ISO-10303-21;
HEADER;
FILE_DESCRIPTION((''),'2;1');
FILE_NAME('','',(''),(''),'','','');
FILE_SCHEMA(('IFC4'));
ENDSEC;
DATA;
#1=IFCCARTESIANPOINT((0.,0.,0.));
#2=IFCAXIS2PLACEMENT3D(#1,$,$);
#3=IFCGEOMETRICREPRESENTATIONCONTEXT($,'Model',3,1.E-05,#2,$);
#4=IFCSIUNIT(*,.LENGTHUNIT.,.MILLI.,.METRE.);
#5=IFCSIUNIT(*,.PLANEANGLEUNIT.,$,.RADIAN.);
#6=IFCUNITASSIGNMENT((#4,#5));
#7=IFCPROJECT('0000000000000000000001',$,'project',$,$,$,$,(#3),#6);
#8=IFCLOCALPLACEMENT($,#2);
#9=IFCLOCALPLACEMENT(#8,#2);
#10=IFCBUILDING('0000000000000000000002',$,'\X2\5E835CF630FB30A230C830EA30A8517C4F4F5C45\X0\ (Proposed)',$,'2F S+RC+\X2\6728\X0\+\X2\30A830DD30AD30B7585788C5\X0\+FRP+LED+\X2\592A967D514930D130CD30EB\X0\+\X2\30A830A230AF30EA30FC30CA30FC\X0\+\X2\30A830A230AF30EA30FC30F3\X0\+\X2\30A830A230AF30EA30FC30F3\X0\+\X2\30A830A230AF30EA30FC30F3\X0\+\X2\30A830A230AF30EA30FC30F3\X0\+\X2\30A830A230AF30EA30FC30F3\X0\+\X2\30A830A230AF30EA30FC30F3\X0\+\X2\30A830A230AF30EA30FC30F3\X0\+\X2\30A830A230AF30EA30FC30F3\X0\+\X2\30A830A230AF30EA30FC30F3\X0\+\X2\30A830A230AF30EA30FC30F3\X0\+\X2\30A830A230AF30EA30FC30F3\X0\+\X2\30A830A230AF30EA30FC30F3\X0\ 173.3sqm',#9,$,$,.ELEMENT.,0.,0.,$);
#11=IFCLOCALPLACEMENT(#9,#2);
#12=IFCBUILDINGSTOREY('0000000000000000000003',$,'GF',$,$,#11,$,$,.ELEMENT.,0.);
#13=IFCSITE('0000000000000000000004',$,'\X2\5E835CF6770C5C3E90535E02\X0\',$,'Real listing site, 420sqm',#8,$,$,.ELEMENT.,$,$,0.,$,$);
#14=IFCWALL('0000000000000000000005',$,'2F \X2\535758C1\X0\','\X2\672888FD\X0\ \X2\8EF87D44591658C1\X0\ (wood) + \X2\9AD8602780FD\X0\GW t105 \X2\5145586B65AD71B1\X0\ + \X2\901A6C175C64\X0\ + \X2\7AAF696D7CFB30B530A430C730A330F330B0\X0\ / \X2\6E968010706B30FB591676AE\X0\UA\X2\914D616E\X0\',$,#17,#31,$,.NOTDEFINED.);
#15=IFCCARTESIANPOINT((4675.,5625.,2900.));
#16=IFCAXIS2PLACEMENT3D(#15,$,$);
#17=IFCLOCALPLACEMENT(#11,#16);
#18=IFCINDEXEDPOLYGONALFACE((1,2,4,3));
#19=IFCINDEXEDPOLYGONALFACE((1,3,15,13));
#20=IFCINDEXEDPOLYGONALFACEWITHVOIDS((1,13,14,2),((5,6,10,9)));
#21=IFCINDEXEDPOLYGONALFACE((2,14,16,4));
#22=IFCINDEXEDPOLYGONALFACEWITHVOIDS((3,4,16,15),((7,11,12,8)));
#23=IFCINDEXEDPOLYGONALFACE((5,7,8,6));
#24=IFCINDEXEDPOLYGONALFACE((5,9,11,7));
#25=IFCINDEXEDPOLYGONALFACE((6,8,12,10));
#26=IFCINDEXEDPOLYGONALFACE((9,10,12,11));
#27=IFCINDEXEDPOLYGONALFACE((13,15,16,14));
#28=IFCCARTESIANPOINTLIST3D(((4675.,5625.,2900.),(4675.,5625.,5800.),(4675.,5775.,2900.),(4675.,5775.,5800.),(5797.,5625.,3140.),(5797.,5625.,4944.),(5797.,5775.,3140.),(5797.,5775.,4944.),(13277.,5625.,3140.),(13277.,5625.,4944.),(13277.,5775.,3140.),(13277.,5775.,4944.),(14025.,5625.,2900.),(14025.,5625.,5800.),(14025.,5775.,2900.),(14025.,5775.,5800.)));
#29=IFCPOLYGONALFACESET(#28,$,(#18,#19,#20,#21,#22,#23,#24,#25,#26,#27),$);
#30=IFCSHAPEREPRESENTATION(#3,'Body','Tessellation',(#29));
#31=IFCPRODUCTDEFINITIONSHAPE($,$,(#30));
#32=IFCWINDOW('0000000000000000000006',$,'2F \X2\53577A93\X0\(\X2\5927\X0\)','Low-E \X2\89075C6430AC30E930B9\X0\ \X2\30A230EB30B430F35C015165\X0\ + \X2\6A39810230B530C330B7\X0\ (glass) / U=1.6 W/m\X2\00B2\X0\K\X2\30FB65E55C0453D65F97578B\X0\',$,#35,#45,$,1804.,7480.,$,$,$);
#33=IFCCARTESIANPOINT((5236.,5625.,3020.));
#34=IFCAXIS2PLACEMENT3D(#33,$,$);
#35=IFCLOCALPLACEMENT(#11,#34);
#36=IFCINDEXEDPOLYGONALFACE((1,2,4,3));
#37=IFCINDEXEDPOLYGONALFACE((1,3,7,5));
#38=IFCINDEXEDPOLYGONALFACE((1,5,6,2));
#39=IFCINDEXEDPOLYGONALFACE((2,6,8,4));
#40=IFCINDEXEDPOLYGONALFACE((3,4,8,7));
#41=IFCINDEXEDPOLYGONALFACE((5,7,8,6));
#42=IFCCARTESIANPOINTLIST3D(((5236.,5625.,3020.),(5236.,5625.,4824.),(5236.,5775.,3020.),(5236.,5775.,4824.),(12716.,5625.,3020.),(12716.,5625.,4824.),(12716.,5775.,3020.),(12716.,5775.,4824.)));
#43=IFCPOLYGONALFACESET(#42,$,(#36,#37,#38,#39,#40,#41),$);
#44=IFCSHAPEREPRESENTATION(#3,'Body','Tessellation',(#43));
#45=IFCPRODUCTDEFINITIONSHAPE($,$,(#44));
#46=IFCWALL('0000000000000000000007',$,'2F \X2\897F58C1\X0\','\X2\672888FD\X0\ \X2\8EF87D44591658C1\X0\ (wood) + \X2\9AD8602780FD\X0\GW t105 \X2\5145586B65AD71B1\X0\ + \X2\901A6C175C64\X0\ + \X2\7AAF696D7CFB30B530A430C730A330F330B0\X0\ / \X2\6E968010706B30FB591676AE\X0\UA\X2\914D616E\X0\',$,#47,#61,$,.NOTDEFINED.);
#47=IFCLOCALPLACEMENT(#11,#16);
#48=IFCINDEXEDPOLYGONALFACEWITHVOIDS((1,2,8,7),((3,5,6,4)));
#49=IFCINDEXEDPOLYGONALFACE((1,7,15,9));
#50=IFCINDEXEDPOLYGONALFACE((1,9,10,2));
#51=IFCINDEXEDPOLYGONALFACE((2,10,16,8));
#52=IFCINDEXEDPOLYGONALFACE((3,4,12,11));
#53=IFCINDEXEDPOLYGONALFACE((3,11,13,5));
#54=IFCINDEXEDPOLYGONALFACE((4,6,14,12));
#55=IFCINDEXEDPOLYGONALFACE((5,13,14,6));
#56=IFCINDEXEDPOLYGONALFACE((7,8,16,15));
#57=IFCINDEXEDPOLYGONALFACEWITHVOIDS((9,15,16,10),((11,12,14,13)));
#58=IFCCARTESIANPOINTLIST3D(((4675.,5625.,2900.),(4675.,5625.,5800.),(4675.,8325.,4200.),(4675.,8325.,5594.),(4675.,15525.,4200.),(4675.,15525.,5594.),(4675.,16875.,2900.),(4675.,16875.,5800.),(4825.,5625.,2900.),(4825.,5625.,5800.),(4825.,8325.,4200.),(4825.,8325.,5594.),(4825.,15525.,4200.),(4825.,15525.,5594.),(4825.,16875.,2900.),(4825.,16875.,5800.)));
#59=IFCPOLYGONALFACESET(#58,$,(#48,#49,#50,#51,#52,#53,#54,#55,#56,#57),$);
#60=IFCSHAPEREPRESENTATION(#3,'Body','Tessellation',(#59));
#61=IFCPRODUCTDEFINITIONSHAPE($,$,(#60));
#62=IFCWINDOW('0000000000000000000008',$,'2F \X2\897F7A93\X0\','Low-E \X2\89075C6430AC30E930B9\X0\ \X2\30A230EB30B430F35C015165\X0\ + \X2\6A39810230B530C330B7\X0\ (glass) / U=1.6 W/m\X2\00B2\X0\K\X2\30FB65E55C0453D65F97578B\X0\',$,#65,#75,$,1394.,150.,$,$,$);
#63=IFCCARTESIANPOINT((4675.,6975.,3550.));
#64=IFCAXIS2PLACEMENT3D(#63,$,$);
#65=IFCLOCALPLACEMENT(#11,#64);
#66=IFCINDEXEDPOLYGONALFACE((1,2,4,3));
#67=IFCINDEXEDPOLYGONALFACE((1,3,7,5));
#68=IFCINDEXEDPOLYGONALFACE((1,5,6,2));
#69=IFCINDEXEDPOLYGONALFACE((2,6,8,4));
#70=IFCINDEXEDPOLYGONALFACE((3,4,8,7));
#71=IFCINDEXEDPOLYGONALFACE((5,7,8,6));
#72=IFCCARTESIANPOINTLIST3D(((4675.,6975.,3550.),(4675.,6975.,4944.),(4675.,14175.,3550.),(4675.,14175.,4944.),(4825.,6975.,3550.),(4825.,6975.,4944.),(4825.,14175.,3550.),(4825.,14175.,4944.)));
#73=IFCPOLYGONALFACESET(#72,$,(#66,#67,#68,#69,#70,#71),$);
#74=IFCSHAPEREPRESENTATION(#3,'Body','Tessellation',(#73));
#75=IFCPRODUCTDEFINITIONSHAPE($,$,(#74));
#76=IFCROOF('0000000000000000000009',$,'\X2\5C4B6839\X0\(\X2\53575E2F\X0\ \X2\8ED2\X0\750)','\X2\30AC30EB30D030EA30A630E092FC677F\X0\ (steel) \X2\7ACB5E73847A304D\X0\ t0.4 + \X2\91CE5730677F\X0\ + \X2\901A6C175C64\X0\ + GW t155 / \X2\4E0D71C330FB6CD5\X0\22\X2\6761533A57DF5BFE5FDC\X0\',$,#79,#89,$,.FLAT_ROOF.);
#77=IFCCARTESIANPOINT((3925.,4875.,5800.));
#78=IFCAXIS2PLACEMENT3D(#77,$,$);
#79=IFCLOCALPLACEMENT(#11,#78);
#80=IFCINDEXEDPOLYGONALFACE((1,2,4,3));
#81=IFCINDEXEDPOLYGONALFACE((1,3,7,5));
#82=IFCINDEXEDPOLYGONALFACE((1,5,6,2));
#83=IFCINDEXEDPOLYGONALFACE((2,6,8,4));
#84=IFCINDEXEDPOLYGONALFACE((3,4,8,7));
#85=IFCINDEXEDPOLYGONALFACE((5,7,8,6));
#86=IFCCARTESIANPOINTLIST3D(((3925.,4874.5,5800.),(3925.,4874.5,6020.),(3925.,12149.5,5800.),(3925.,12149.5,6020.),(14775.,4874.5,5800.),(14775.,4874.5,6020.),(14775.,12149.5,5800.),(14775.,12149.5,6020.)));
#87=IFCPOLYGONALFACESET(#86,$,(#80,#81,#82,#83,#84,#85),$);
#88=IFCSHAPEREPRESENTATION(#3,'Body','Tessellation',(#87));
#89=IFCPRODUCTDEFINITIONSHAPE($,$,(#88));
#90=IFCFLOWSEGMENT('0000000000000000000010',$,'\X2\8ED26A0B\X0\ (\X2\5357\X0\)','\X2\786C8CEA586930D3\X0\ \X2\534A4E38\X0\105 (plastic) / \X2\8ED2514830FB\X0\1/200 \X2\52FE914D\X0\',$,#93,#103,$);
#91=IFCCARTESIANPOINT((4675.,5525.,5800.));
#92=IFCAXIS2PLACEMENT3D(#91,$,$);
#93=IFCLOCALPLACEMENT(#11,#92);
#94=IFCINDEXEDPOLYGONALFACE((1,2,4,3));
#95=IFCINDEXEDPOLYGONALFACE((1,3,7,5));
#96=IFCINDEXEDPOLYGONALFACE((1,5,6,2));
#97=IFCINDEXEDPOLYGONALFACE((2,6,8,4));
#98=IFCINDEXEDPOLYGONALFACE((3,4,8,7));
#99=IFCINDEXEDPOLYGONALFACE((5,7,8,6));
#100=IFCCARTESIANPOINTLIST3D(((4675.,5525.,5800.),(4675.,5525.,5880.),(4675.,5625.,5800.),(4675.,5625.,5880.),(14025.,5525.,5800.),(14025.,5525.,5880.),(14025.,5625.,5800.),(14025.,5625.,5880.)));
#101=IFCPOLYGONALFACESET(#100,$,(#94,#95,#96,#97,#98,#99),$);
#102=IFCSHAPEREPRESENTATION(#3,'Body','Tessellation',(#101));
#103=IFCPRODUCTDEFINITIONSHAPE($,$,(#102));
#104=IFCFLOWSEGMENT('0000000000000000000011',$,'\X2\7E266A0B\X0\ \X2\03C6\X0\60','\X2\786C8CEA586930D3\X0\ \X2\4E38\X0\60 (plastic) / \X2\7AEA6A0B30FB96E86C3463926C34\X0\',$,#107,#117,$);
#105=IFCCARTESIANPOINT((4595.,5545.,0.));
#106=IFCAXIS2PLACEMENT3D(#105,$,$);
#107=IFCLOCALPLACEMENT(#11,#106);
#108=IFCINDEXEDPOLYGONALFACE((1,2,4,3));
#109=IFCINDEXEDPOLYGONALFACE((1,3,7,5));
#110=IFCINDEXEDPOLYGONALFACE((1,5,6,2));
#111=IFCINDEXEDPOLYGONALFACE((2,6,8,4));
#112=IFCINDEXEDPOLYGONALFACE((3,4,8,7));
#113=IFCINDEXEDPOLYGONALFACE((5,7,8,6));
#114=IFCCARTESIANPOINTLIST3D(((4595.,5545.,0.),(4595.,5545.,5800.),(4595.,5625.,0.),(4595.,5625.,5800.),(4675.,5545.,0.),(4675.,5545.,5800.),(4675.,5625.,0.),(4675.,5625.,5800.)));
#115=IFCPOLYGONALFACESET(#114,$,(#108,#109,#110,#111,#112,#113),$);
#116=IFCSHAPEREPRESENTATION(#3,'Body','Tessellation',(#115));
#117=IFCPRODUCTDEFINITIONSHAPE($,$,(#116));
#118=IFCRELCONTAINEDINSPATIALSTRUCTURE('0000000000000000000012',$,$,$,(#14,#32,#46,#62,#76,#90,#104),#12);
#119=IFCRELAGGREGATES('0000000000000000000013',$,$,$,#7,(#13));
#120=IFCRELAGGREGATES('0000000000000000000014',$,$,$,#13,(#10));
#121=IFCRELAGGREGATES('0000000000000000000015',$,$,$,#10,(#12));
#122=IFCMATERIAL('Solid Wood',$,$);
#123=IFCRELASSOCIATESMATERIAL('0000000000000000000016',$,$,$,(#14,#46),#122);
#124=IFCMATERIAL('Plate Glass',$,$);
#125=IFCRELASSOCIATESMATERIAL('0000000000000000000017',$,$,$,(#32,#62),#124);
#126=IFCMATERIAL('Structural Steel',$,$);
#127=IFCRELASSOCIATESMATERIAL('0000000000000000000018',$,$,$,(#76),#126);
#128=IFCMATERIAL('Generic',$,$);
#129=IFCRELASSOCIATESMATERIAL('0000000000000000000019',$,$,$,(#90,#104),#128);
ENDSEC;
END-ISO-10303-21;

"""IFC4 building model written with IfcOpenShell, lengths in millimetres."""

from ifc_helpers import new_model, si_unit, frame, frame_2d, origin, place, context, project, spatial, rectangle, extrude, material, element, fill, save


model = new_model("IFC4")

# Units and contexts
model_context = context("Model", 3, precision=1e-05, world=origin())
ifc_project = project(units=[si_unit("LENGTHUNIT", "METRE", prefix="MILLI"), si_unit("PLANEANGLEUNIT", "RADIAN")], contexts=[model_context])

# Site, building, storey
site_placement = place(None, origin())
site = spatial("IfcSite", under=ifc_project, at=site_placement, Name="広島県尾道市", ObjectType="Real listing site, 420sqm", CompositionType="ELEMENT", RefElevation=0.0)
building_placement = place(site_placement, origin())
building = spatial("IfcBuilding", under=site, at=building_placement, Name="広島・アトリエ兼住居 (Proposed)", ObjectType="2F S+RC+木+エポキシ塗装+FRP+LED+太陽光パネル+エアクリーナー+エアクリーン+エアクリーン+エアクリーン+エアクリーン+エアクリーン+エアクリーン+エアクリーン+エアクリーン+エアクリーン+エアクリーン+エアクリーン+エアクリーン 173.3sqm", CompositionType="ELEMENT", ElevationOfRefHeight=0.0, ElevationOfTerrain=0.0)
storey_placement = place(building_placement, origin())
storey = spatial("IfcBuildingStorey", under=building, at=storey_placement, Name="GF", CompositionType="ELEMENT", Elevation=0.0)

# Shared definitions
ifc_material_1 = material(Name="Solid Wood")

# Shared definitions
ifc_material_2 = material(Name="Plate Glass")

# Walls, openings, windows
wall_1_placement = place(storey_placement, frame((4675.0, 5625.0, 2900.0)))
wall_1 = element("IfcWall", 1, at=wall_1_placement, inside=storey, material=ifc_material_1, Name="2F 南壁", Description="木製 軸組外壁 (wood) + 高性能GW t105 充填断熱 + 通気層 + 窯業系サイディング / 準耐火・外皮UA配慮", PredefinedType="NOTDEFINED", context=model_context, shape_type="SweptSolid", body=[
    extrude(rectangle(XDim=9350.0, YDim=150.0, at=frame_2d((4675.0, 75.0))), frame((4675.0, 5625.0, 2900.0)), (0.0, 0.0, 1.0), 2900.0),
])
opening_1_placement = place(storey_placement, frame((5236.0, 5625.0, 3020.0)))
opening_1 = element("IfcOpeningElement", 2, at=opening_1_placement, cuts=wall_1, PredefinedType="NOTDEFINED", context=model_context, shape_type="SweptSolid", body=[
    extrude(rectangle(XDim=7480.0, YDim=150.0, at=frame_2d((3740.0, 75.0))), frame((5236.0, 5625.0, 3020.0)), (0.0, 0.0, 1.0), 1804.0),
])
window_1_placement = place(storey_placement, frame((5236.0, 5625.0, 3020.0)))
window_1 = element("IfcWindow", 3, at=window_1_placement, inside=storey, material=ifc_material_2, Name="2F 南窓(大)", Description="Low-E 複層ガラス アルゴン封入 + 樹脂サッシ (glass) / U=1.6 W/m²K・日射取得型", OverallHeight=1804.0, OverallWidth=7480.0, context=model_context, shape_type="SweptSolid", body=[
    extrude(rectangle(XDim=7480.0, YDim=150.0, at=frame_2d((3740.0, 75.0))), frame((5236.0, 5625.0, 3020.0)), (0.0, 0.0, 1.0), 1804.0),
])
fill(opening_1, window_1)
wall_2_placement = place(storey_placement, frame((4675.0, 5625.0, 2900.0)))
wall_2 = element("IfcWall", 4, at=wall_2_placement, inside=storey, material=ifc_material_1, Name="2F 西壁", Description="木製 軸組外壁 (wood) + 高性能GW t105 充填断熱 + 通気層 + 窯業系サイディング / 準耐火・外皮UA配慮", PredefinedType="NOTDEFINED", context=model_context, shape_type="SweptSolid", body=[
    extrude(rectangle(XDim=150.0, YDim=11250.0, at=frame_2d((75.0, 5625.0))), frame((4675.0, 5625.0, 2900.0)), (0.0, 0.0, 1.0), 2900.0),
])
opening_2_placement = place(storey_placement, frame((4675.0, 6975.0, 3550.0)))
opening_2 = element("IfcOpeningElement", 5, at=opening_2_placement, cuts=wall_2, PredefinedType="NOTDEFINED", context=model_context, shape_type="SweptSolid", body=[
    extrude(rectangle(XDim=150.0, YDim=7200.0, at=frame_2d((75.0, 3600.0))), frame((4675.0, 6975.0, 3550.0)), (0.0, 0.0, 1.0), 1394.0),
])
window_2_placement = place(storey_placement, frame((4675.0, 6975.0, 3550.0)))
window_2 = element("IfcWindow", 6, at=window_2_placement, inside=storey, material=ifc_material_2, Name="2F 西窓", Description="Low-E 複層ガラス アルゴン封入 + 樹脂サッシ (glass) / U=1.6 W/m²K・日射取得型", OverallHeight=1394.0, OverallWidth=150.0, context=model_context, shape_type="SweptSolid", body=[
    extrude(rectangle(XDim=150.0, YDim=7200.0, at=frame_2d((75.0, 3600.0))), frame((4675.0, 6975.0, 3550.0)), (0.0, 0.0, 1.0), 1394.0),
])
fill(opening_2, window_2)

# Roof
ifc_material_3 = material(Name="Structural Steel")
for number, where, name in (
    (7, (3925.0, 4875.0, 5800.0), "屋根(南帯 軒750)"),
):
    element("IfcRoof", number, at=place(storey_placement, frame(where)), inside=storey, material=ifc_material_3, Name=name, Description="ガルバリウム鋼板 (steel) 立平葺き t0.4 + 野地板 + 通気層 + GW t155 / 不燃・法22条区域対応", PredefinedType="FLAT_ROOF", context=model_context, shape_type="SweptSolid", body=[
        extrude(rectangle(XDim=10850.0, YDim=7275.0, at=frame_2d((5425.0, 3637.0))), frame((3925.0, 4875.0, 5800.0)), (0.0, 0.0, 1.0), 220.0),
    ])

# Flow segments
ifc_material_4 = material(Name="Generic")
flow_segment_1_placement = place(storey_placement, frame((4675.0, 5525.0, 5800.0)))
element("IfcFlowSegment", 8, at=flow_segment_1_placement, inside=storey, material=ifc_material_4, Name="軒樋 (南)", Description="硬質塩ビ 半丸105 (plastic) / 軒先・1/200 勾配", context=model_context, shape_type="SweptSolid", body=[
    extrude(rectangle(XDim=9350.0, YDim=100.0, at=frame_2d((4675.0, 50.0))), frame((4675.0, 5525.0, 5800.0)), (0.0, 0.0, 1.0), 80.0),
])
flow_segment_2_placement = place(storey_placement, frame((4595.0, 5545.0, 0.0)))
element("IfcFlowSegment", 9, at=flow_segment_2_placement, inside=storey, material=ifc_material_4, Name="縦樋 φ60", Description="硬質塩ビ 丸60 (plastic) / 竪樋・雨水排水", context=model_context, shape_type="SweptSolid", body=[
    extrude(rectangle(XDim=80.0, YDim=80.0, at=frame_2d((40.0, 40.0))), frame((4595.0, 5545.0, 0.0)), (0.0, 0.0, 1.0), 5800.0),
])

save(model, "model.ifc")
